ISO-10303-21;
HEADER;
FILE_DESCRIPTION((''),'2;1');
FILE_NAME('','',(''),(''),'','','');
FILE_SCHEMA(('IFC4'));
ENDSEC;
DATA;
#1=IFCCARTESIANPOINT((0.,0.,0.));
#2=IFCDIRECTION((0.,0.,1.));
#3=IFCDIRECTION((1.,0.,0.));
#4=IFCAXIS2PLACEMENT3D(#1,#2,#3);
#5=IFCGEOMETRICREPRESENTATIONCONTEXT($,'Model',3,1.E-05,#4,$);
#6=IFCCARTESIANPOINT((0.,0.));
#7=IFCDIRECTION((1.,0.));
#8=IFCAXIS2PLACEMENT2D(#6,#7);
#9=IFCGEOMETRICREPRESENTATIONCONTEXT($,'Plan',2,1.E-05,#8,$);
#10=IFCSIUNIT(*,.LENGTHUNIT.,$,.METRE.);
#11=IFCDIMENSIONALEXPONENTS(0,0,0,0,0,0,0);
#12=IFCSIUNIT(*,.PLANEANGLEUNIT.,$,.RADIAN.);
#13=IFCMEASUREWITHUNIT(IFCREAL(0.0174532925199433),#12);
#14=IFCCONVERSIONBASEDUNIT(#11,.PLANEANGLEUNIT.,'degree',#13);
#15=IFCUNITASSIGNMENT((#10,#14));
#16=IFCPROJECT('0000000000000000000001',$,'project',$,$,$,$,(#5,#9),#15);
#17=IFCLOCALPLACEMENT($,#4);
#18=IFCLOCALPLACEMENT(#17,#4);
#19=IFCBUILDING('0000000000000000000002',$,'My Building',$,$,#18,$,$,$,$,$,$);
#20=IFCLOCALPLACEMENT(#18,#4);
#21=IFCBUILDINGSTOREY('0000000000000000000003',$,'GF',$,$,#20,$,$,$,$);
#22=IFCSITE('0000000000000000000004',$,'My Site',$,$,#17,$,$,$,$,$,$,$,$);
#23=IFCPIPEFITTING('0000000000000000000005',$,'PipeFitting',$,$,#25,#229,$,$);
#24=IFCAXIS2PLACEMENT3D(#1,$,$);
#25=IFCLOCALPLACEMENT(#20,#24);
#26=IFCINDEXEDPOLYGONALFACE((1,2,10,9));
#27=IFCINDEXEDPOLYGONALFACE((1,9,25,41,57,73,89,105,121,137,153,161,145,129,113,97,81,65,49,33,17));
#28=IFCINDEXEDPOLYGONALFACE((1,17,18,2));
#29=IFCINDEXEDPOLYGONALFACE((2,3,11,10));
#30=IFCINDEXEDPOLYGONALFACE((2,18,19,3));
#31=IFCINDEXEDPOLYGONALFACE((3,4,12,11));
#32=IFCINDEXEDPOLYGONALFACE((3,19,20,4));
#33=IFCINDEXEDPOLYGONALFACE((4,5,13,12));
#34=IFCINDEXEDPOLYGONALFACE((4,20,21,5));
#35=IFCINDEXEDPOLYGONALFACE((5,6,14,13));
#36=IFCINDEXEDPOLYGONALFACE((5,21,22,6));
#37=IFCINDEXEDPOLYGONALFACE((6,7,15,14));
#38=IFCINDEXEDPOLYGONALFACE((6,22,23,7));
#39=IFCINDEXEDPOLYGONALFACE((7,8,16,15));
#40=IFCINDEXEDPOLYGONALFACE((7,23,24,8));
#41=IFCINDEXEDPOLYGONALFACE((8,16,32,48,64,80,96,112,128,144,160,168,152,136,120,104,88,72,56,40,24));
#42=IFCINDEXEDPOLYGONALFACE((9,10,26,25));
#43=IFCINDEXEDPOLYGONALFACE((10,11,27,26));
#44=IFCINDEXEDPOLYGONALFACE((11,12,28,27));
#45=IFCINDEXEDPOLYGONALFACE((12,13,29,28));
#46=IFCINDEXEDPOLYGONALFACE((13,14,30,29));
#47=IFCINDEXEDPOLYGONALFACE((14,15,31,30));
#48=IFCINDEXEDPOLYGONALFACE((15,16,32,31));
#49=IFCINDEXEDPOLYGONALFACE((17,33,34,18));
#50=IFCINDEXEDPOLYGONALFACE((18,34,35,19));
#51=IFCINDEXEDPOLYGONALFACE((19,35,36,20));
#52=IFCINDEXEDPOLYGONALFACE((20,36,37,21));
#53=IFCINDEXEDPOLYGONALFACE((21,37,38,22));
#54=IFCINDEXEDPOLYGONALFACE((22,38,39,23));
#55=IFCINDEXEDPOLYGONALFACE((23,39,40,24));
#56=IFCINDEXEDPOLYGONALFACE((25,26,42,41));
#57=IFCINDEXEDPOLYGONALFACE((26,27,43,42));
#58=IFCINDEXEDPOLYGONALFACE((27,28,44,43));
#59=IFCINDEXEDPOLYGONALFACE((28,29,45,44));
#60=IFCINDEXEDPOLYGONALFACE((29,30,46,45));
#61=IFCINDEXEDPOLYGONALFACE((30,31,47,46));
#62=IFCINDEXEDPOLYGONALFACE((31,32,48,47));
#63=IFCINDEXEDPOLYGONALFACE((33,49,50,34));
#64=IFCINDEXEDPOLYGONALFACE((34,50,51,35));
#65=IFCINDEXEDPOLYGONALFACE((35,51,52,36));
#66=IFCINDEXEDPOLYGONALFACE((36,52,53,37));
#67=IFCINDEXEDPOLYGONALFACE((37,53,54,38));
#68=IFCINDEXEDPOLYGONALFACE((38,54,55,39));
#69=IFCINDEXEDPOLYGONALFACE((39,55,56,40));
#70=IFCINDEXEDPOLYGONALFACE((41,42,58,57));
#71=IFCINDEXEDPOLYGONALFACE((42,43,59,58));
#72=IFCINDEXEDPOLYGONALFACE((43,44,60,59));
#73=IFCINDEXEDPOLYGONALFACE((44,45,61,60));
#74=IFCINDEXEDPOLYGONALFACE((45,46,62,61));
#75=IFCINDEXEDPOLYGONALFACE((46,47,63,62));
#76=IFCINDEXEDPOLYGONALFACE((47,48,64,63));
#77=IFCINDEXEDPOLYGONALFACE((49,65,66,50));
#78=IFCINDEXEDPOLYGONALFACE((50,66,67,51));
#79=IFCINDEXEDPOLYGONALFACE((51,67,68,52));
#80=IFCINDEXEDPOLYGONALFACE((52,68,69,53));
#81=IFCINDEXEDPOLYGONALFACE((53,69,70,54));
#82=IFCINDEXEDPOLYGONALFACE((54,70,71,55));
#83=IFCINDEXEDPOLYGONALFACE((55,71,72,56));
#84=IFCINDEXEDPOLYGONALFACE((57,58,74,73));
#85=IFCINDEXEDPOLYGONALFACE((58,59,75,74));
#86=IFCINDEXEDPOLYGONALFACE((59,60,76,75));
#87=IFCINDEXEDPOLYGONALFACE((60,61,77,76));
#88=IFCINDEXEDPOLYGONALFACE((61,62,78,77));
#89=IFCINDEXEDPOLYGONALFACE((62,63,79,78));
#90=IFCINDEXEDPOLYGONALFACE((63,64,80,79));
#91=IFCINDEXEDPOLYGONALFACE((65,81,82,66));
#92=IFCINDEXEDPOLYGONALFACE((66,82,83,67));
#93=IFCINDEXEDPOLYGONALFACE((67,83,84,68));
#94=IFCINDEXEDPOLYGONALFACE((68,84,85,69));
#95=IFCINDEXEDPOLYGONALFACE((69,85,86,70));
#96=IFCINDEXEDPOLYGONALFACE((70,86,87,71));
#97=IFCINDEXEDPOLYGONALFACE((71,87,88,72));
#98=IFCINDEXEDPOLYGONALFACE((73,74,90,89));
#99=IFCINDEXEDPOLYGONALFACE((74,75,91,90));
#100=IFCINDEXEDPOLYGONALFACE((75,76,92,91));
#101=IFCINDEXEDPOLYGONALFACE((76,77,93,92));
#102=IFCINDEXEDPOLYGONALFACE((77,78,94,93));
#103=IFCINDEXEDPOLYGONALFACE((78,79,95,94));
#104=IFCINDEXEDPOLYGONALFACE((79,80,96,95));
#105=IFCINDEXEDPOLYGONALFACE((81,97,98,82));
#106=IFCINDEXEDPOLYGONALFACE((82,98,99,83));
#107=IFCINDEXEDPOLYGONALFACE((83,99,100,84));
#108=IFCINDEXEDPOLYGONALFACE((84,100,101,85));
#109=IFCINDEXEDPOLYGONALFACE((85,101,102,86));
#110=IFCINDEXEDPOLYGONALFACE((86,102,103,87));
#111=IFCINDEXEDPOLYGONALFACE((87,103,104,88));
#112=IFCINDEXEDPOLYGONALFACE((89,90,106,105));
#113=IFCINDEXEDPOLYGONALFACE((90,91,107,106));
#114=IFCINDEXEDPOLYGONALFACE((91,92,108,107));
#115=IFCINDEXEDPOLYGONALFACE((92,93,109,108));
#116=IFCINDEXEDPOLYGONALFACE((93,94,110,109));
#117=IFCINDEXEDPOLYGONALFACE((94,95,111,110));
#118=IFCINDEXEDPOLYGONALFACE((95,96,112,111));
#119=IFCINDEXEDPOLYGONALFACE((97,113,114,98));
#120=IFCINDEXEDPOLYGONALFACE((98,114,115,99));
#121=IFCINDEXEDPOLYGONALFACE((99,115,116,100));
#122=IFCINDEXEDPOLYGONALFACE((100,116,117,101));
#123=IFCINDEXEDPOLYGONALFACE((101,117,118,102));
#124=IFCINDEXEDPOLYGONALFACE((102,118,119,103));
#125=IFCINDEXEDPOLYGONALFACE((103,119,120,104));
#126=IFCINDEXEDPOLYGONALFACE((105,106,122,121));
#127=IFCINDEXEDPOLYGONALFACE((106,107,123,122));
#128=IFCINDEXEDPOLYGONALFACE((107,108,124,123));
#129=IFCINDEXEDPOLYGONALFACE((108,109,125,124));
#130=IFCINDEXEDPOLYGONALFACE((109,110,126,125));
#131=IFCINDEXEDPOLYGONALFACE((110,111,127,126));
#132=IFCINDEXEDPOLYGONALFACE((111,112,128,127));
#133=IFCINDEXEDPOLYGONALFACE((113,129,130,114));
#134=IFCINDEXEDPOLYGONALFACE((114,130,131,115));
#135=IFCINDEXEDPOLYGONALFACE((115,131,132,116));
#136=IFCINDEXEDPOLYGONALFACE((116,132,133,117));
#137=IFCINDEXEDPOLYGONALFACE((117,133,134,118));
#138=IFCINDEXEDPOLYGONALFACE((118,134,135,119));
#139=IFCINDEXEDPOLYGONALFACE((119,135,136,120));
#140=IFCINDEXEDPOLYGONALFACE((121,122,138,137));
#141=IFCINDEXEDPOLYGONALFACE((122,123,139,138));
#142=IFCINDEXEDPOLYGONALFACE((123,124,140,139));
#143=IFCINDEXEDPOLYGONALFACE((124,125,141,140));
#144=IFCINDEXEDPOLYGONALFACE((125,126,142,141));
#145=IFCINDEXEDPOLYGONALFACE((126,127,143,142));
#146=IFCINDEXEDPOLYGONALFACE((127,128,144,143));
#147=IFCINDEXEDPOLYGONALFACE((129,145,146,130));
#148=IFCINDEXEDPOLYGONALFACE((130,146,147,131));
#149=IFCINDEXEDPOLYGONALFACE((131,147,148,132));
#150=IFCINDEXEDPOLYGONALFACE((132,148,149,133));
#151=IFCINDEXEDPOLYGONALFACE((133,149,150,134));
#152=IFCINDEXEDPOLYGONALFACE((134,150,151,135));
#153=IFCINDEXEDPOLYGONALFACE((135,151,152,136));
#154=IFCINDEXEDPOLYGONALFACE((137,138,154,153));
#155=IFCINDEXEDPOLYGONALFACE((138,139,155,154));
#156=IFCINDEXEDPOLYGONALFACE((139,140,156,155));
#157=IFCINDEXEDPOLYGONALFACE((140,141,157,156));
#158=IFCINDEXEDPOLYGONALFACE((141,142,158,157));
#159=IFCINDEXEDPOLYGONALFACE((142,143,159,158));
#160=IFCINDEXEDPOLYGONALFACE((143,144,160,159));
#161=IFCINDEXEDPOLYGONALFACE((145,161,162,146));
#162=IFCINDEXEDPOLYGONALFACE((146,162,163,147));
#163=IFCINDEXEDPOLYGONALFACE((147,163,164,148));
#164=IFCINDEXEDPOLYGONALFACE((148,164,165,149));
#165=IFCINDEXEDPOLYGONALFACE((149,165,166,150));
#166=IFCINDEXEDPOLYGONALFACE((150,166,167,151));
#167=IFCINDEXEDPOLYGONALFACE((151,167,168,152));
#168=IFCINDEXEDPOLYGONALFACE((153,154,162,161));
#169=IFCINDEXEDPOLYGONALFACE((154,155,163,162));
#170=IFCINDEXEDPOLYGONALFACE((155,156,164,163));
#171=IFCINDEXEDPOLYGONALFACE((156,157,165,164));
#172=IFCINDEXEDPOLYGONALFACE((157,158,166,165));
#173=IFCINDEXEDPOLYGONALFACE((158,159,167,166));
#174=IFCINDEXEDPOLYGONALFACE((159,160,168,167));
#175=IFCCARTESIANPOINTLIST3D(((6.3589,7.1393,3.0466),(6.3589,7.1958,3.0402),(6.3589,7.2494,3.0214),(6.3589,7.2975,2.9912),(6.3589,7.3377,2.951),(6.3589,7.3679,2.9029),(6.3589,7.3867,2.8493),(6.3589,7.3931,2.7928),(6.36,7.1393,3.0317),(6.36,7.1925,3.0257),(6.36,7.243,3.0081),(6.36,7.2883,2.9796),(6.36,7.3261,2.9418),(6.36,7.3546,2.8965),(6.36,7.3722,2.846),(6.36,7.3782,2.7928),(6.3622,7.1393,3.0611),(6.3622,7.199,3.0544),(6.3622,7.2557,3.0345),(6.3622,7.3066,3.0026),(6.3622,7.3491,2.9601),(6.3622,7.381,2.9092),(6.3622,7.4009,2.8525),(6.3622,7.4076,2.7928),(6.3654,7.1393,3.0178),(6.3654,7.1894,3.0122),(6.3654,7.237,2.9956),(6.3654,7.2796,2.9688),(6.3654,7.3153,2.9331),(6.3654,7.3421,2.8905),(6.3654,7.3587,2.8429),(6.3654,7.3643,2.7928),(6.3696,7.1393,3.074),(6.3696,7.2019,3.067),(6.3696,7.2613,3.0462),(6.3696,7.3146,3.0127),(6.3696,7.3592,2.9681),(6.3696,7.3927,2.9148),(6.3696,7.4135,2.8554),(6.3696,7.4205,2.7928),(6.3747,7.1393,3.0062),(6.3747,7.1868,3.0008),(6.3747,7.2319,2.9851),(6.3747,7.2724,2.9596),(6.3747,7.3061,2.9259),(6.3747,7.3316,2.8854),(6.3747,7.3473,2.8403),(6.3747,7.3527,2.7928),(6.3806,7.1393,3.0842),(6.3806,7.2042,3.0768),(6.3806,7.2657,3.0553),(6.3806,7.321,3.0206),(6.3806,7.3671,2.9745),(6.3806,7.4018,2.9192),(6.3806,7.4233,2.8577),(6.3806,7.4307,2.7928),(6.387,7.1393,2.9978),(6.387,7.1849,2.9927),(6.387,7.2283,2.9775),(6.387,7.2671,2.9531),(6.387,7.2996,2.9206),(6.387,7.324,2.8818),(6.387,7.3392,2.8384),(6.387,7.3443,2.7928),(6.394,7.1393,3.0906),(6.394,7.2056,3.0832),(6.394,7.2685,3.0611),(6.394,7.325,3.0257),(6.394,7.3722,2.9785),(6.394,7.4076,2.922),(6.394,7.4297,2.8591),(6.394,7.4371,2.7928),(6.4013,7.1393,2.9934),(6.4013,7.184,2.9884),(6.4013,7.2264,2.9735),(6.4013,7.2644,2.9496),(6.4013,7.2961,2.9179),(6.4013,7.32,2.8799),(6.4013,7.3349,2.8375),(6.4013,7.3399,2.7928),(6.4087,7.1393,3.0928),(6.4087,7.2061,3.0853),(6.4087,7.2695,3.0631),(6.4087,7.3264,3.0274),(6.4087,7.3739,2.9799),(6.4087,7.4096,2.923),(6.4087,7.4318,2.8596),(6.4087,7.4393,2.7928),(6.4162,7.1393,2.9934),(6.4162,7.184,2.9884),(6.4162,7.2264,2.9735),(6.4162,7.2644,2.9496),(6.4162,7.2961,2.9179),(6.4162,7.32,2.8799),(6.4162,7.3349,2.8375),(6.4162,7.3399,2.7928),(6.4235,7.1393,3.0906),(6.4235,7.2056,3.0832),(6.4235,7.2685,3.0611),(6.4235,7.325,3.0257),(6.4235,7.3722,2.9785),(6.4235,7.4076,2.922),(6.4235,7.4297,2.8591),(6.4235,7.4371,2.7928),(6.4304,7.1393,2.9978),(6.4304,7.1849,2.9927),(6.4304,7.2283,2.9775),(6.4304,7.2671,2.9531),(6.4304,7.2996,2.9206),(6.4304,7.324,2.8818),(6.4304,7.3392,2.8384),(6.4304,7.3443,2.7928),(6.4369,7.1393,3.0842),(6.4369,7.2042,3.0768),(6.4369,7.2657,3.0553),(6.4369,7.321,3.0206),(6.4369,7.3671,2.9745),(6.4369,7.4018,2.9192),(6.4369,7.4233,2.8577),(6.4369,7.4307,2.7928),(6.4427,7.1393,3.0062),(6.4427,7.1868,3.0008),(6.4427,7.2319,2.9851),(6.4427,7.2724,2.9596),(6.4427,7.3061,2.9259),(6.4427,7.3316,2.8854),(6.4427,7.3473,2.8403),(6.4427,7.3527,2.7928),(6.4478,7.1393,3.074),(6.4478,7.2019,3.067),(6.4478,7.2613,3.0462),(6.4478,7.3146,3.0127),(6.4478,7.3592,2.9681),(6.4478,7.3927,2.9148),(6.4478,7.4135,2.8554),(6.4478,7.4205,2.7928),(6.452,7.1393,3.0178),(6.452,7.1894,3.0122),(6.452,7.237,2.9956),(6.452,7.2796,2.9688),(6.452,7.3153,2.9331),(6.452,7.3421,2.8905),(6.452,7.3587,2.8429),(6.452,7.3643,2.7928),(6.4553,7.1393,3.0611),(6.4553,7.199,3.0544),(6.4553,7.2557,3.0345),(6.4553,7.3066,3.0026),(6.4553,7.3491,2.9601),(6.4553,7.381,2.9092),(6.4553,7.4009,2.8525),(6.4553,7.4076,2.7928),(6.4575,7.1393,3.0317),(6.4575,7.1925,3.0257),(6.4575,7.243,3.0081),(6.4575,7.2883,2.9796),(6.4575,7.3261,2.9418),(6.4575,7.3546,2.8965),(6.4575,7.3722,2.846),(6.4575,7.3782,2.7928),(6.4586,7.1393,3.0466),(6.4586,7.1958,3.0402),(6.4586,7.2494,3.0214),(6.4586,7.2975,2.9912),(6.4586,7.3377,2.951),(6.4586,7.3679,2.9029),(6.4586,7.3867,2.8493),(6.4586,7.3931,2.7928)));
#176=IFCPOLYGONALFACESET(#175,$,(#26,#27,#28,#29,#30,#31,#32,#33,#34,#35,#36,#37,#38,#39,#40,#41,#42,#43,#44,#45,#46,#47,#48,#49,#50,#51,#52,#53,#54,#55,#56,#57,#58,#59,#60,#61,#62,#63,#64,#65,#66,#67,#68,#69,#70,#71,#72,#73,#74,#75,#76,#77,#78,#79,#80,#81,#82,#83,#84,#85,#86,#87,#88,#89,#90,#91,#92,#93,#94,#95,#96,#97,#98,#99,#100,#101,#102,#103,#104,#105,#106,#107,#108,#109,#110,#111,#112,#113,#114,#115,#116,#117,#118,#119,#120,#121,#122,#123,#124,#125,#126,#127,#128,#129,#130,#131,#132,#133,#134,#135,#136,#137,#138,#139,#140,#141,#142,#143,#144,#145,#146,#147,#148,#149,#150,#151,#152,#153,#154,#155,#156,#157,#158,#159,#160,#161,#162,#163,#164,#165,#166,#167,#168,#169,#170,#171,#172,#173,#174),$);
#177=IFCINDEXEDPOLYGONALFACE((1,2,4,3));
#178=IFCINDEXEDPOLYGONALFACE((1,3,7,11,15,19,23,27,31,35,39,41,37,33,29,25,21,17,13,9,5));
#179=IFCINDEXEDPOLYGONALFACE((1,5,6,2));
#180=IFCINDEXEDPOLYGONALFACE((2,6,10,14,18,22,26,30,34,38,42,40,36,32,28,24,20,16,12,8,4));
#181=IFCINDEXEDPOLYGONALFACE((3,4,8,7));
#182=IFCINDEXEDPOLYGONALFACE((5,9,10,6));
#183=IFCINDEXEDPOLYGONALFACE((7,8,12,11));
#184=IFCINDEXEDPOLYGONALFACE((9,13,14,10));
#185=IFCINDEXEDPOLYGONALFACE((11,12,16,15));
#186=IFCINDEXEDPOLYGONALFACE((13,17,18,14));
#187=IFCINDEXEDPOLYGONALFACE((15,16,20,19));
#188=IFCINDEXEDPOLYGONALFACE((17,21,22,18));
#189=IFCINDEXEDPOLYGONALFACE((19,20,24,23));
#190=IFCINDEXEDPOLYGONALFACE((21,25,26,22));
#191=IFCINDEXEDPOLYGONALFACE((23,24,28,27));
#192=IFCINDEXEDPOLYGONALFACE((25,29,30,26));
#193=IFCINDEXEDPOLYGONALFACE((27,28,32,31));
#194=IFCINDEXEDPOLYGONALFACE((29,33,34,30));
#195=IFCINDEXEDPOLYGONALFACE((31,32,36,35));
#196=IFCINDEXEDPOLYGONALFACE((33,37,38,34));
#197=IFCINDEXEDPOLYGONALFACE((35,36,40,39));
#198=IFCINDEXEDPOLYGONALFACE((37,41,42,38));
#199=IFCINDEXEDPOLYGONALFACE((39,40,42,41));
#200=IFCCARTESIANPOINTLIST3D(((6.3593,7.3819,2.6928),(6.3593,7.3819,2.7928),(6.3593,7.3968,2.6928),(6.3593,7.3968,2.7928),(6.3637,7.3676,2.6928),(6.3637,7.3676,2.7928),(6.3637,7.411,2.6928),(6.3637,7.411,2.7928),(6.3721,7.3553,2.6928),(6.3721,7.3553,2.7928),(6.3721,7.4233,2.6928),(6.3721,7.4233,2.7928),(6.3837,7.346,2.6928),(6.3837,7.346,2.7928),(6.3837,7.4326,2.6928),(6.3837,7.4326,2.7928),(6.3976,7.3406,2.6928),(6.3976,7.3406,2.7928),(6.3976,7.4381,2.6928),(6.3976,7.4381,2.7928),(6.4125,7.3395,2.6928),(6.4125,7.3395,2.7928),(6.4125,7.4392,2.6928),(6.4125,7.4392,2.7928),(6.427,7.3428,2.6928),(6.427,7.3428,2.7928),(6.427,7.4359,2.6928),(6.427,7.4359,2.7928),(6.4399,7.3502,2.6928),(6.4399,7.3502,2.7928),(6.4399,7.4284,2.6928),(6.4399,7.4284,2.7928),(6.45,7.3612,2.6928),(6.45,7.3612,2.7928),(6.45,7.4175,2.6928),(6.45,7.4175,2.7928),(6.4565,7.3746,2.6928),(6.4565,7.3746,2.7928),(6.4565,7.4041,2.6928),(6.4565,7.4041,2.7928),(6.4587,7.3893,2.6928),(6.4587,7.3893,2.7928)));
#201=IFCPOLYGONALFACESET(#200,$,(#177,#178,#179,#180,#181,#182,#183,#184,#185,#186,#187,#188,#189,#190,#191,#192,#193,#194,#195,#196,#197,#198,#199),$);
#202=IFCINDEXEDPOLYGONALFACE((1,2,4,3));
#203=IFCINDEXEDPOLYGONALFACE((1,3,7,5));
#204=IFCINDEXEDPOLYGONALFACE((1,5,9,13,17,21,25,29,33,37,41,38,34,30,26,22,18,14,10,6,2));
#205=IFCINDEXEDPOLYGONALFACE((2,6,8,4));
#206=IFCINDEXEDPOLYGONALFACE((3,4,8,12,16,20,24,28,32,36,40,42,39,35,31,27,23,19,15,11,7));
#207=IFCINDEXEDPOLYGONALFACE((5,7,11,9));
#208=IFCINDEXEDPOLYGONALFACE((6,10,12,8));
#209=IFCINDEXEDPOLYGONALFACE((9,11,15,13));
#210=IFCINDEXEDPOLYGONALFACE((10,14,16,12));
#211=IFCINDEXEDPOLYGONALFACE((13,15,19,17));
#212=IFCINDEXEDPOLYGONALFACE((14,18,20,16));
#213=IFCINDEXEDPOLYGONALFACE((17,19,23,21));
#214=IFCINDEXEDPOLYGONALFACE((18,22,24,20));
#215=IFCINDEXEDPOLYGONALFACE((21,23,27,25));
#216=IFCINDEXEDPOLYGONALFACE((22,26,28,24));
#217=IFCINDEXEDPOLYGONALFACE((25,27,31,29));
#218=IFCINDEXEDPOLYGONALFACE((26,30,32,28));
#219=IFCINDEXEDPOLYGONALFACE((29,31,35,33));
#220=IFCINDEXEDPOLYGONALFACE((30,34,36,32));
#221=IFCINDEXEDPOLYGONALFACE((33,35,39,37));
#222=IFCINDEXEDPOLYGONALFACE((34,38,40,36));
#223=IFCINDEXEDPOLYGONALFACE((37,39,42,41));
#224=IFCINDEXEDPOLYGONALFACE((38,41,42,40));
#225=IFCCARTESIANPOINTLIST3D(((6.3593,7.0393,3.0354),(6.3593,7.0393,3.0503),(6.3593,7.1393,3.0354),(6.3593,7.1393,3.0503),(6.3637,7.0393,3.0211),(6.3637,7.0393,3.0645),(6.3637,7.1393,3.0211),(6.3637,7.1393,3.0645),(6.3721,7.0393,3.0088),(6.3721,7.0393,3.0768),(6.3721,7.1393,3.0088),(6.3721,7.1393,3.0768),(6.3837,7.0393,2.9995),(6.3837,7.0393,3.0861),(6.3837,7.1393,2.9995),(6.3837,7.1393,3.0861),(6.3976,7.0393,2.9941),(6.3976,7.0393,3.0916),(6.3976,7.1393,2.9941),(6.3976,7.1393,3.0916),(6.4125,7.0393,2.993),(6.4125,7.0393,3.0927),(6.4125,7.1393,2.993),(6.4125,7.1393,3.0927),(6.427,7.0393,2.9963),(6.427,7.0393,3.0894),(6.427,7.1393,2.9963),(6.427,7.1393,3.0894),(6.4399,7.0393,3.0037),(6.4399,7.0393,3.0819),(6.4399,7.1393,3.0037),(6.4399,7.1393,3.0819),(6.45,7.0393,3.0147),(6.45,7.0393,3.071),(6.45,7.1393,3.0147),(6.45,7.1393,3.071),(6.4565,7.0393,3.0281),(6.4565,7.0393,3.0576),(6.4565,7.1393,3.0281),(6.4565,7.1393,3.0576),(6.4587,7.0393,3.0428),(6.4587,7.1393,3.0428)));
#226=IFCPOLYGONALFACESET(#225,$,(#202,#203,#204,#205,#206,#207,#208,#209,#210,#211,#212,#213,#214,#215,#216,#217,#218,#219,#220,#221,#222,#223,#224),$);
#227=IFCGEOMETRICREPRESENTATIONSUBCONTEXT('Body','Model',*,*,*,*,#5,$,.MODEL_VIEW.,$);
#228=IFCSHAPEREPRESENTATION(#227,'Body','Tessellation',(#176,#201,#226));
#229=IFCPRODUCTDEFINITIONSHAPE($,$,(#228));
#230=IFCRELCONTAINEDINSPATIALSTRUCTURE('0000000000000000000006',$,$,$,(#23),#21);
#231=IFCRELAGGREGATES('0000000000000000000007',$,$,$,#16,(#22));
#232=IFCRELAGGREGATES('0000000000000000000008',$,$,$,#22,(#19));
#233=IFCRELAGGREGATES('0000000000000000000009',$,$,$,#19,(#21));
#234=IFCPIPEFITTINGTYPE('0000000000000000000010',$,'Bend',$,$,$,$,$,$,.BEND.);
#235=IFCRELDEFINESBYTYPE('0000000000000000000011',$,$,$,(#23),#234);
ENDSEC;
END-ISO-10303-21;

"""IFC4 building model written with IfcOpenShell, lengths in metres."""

from ifc_helpers import new_model, entity, si_unit, converted_unit, frame, origin_with_axes, origin_2d_with_axis, place, context, subcontext, project, spatial, line, indexed_curve, circle, outline, extrude, source, transform, mapped, type_object, type_shapes, element, save


model = new_model("IFC4")

# Units and contexts
model_context = context("Model", 3, precision=1e-05, world=origin_with_axes())
plan_context = context("Plan", 2, precision=1e-05, world=origin_2d_with_axis())
body_context_1 = subcontext(model_context, "Body", "Model", "MODEL_VIEW")
ifc_project = project(units=[si_unit("LENGTHUNIT", "METRE"), converted_unit("PLANEANGLEUNIT", "degree", entity("IfcReal", 0.0174532925199433), si_unit("PLANEANGLEUNIT", "RADIAN"), dimensions=[0, 0, 0, 0, 0, 0, 0])], contexts=[model_context, plan_context])

# Site, building, storey
site_placement = place(None, origin_with_axes())
site = spatial("IfcSite", under=ifc_project, at=site_placement, Name="My Site")
building_placement = place(site_placement, origin_with_axes())
building = spatial("IfcBuilding", under=site, at=building_placement, Name="My Building")
storey_placement = place(building_placement, origin_with_axes())
storey = spatial("IfcBuildingStorey", under=building, at=storey_placement, Name="GF")

# Pipe fitting, opening
pipe_fitting_type = type_object("IfcPipeFittingType", Name="Bend", PredefinedType="BEND")
shared_shape_1 = source(origin_with_axes(), body_context_1, "Body", "SolidModel", [
    entity("IfcSweptDiskSolid", entity("IfcIndexedPolyCurve", entity("IfcCartesianPointList3D", [[0.0, 0.0, 0.1], [0.0, -0.0732, 0.2768], [0.0, -0.25, 0.35]]), [entity("IfcArcIndex", [1, 2, 3])]), 0.05),
    extrude(circle(Radius=0.05), origin_with_axes(), (0.0, 0.0, 1.0), 0.1),
    extrude(circle(Radius=0.05), frame((0.0, -0.25, 0.35), z_axis=(0.0, -1.0, 0.0), x_axis=(1.0, 0.0, 0.0)), (0.0, 0.0, 1.0), 0.1),
])
type_shapes(pipe_fitting_type, [shared_shape_1])
pipe_fitting_1_placement = place(storey_placement, frame((6.4087, 7.3893, 2.6928), z_axis=(0.0, 0.0, 1.0), x_axis=(1.0, 0.0, 0.0)))
pipe_fitting_1 = element("IfcPipeFitting", 1, at=pipe_fitting_1_placement, inside=storey, type_object=pipe_fitting_type, Name="PipeFitting", context=body_context_1, shape_type="MappedRepresentation", body=[
    mapped(shared_shape_1, transform((0.0, 0.0, 0.0), x_axis=(1.0, 0.0, 0.0), y_axis=(0.0, 1.0, 0.0), z_axis=(0.0, 0.0, 1.0), scale=1.0)),
])
opening_1_placement = place(pipe_fitting_1_placement, frame((-6.4087, -7.3893, -2.6928), z_axis=(0.0, 0.0, 1.0), x_axis=(1.0, 0.0, 0.0)))
element("IfcOpeningElement", 2, at=opening_1_placement, cuts=pipe_fitting_1, PredefinedType="OPENING", context=body_context_1, shape_type="SweptSolid", body=[
    extrude(outline(indexed_curve([(0.0, 0.0), (0.5, 0.0), (0.5, 0.5), (0.0, 0.5)], segments=[line(1, 2, 3, 4, 1)])), origin_with_axes(), (0.0, 0.0, 1.0), 0.5),
])

save(model, "model.ifc")
